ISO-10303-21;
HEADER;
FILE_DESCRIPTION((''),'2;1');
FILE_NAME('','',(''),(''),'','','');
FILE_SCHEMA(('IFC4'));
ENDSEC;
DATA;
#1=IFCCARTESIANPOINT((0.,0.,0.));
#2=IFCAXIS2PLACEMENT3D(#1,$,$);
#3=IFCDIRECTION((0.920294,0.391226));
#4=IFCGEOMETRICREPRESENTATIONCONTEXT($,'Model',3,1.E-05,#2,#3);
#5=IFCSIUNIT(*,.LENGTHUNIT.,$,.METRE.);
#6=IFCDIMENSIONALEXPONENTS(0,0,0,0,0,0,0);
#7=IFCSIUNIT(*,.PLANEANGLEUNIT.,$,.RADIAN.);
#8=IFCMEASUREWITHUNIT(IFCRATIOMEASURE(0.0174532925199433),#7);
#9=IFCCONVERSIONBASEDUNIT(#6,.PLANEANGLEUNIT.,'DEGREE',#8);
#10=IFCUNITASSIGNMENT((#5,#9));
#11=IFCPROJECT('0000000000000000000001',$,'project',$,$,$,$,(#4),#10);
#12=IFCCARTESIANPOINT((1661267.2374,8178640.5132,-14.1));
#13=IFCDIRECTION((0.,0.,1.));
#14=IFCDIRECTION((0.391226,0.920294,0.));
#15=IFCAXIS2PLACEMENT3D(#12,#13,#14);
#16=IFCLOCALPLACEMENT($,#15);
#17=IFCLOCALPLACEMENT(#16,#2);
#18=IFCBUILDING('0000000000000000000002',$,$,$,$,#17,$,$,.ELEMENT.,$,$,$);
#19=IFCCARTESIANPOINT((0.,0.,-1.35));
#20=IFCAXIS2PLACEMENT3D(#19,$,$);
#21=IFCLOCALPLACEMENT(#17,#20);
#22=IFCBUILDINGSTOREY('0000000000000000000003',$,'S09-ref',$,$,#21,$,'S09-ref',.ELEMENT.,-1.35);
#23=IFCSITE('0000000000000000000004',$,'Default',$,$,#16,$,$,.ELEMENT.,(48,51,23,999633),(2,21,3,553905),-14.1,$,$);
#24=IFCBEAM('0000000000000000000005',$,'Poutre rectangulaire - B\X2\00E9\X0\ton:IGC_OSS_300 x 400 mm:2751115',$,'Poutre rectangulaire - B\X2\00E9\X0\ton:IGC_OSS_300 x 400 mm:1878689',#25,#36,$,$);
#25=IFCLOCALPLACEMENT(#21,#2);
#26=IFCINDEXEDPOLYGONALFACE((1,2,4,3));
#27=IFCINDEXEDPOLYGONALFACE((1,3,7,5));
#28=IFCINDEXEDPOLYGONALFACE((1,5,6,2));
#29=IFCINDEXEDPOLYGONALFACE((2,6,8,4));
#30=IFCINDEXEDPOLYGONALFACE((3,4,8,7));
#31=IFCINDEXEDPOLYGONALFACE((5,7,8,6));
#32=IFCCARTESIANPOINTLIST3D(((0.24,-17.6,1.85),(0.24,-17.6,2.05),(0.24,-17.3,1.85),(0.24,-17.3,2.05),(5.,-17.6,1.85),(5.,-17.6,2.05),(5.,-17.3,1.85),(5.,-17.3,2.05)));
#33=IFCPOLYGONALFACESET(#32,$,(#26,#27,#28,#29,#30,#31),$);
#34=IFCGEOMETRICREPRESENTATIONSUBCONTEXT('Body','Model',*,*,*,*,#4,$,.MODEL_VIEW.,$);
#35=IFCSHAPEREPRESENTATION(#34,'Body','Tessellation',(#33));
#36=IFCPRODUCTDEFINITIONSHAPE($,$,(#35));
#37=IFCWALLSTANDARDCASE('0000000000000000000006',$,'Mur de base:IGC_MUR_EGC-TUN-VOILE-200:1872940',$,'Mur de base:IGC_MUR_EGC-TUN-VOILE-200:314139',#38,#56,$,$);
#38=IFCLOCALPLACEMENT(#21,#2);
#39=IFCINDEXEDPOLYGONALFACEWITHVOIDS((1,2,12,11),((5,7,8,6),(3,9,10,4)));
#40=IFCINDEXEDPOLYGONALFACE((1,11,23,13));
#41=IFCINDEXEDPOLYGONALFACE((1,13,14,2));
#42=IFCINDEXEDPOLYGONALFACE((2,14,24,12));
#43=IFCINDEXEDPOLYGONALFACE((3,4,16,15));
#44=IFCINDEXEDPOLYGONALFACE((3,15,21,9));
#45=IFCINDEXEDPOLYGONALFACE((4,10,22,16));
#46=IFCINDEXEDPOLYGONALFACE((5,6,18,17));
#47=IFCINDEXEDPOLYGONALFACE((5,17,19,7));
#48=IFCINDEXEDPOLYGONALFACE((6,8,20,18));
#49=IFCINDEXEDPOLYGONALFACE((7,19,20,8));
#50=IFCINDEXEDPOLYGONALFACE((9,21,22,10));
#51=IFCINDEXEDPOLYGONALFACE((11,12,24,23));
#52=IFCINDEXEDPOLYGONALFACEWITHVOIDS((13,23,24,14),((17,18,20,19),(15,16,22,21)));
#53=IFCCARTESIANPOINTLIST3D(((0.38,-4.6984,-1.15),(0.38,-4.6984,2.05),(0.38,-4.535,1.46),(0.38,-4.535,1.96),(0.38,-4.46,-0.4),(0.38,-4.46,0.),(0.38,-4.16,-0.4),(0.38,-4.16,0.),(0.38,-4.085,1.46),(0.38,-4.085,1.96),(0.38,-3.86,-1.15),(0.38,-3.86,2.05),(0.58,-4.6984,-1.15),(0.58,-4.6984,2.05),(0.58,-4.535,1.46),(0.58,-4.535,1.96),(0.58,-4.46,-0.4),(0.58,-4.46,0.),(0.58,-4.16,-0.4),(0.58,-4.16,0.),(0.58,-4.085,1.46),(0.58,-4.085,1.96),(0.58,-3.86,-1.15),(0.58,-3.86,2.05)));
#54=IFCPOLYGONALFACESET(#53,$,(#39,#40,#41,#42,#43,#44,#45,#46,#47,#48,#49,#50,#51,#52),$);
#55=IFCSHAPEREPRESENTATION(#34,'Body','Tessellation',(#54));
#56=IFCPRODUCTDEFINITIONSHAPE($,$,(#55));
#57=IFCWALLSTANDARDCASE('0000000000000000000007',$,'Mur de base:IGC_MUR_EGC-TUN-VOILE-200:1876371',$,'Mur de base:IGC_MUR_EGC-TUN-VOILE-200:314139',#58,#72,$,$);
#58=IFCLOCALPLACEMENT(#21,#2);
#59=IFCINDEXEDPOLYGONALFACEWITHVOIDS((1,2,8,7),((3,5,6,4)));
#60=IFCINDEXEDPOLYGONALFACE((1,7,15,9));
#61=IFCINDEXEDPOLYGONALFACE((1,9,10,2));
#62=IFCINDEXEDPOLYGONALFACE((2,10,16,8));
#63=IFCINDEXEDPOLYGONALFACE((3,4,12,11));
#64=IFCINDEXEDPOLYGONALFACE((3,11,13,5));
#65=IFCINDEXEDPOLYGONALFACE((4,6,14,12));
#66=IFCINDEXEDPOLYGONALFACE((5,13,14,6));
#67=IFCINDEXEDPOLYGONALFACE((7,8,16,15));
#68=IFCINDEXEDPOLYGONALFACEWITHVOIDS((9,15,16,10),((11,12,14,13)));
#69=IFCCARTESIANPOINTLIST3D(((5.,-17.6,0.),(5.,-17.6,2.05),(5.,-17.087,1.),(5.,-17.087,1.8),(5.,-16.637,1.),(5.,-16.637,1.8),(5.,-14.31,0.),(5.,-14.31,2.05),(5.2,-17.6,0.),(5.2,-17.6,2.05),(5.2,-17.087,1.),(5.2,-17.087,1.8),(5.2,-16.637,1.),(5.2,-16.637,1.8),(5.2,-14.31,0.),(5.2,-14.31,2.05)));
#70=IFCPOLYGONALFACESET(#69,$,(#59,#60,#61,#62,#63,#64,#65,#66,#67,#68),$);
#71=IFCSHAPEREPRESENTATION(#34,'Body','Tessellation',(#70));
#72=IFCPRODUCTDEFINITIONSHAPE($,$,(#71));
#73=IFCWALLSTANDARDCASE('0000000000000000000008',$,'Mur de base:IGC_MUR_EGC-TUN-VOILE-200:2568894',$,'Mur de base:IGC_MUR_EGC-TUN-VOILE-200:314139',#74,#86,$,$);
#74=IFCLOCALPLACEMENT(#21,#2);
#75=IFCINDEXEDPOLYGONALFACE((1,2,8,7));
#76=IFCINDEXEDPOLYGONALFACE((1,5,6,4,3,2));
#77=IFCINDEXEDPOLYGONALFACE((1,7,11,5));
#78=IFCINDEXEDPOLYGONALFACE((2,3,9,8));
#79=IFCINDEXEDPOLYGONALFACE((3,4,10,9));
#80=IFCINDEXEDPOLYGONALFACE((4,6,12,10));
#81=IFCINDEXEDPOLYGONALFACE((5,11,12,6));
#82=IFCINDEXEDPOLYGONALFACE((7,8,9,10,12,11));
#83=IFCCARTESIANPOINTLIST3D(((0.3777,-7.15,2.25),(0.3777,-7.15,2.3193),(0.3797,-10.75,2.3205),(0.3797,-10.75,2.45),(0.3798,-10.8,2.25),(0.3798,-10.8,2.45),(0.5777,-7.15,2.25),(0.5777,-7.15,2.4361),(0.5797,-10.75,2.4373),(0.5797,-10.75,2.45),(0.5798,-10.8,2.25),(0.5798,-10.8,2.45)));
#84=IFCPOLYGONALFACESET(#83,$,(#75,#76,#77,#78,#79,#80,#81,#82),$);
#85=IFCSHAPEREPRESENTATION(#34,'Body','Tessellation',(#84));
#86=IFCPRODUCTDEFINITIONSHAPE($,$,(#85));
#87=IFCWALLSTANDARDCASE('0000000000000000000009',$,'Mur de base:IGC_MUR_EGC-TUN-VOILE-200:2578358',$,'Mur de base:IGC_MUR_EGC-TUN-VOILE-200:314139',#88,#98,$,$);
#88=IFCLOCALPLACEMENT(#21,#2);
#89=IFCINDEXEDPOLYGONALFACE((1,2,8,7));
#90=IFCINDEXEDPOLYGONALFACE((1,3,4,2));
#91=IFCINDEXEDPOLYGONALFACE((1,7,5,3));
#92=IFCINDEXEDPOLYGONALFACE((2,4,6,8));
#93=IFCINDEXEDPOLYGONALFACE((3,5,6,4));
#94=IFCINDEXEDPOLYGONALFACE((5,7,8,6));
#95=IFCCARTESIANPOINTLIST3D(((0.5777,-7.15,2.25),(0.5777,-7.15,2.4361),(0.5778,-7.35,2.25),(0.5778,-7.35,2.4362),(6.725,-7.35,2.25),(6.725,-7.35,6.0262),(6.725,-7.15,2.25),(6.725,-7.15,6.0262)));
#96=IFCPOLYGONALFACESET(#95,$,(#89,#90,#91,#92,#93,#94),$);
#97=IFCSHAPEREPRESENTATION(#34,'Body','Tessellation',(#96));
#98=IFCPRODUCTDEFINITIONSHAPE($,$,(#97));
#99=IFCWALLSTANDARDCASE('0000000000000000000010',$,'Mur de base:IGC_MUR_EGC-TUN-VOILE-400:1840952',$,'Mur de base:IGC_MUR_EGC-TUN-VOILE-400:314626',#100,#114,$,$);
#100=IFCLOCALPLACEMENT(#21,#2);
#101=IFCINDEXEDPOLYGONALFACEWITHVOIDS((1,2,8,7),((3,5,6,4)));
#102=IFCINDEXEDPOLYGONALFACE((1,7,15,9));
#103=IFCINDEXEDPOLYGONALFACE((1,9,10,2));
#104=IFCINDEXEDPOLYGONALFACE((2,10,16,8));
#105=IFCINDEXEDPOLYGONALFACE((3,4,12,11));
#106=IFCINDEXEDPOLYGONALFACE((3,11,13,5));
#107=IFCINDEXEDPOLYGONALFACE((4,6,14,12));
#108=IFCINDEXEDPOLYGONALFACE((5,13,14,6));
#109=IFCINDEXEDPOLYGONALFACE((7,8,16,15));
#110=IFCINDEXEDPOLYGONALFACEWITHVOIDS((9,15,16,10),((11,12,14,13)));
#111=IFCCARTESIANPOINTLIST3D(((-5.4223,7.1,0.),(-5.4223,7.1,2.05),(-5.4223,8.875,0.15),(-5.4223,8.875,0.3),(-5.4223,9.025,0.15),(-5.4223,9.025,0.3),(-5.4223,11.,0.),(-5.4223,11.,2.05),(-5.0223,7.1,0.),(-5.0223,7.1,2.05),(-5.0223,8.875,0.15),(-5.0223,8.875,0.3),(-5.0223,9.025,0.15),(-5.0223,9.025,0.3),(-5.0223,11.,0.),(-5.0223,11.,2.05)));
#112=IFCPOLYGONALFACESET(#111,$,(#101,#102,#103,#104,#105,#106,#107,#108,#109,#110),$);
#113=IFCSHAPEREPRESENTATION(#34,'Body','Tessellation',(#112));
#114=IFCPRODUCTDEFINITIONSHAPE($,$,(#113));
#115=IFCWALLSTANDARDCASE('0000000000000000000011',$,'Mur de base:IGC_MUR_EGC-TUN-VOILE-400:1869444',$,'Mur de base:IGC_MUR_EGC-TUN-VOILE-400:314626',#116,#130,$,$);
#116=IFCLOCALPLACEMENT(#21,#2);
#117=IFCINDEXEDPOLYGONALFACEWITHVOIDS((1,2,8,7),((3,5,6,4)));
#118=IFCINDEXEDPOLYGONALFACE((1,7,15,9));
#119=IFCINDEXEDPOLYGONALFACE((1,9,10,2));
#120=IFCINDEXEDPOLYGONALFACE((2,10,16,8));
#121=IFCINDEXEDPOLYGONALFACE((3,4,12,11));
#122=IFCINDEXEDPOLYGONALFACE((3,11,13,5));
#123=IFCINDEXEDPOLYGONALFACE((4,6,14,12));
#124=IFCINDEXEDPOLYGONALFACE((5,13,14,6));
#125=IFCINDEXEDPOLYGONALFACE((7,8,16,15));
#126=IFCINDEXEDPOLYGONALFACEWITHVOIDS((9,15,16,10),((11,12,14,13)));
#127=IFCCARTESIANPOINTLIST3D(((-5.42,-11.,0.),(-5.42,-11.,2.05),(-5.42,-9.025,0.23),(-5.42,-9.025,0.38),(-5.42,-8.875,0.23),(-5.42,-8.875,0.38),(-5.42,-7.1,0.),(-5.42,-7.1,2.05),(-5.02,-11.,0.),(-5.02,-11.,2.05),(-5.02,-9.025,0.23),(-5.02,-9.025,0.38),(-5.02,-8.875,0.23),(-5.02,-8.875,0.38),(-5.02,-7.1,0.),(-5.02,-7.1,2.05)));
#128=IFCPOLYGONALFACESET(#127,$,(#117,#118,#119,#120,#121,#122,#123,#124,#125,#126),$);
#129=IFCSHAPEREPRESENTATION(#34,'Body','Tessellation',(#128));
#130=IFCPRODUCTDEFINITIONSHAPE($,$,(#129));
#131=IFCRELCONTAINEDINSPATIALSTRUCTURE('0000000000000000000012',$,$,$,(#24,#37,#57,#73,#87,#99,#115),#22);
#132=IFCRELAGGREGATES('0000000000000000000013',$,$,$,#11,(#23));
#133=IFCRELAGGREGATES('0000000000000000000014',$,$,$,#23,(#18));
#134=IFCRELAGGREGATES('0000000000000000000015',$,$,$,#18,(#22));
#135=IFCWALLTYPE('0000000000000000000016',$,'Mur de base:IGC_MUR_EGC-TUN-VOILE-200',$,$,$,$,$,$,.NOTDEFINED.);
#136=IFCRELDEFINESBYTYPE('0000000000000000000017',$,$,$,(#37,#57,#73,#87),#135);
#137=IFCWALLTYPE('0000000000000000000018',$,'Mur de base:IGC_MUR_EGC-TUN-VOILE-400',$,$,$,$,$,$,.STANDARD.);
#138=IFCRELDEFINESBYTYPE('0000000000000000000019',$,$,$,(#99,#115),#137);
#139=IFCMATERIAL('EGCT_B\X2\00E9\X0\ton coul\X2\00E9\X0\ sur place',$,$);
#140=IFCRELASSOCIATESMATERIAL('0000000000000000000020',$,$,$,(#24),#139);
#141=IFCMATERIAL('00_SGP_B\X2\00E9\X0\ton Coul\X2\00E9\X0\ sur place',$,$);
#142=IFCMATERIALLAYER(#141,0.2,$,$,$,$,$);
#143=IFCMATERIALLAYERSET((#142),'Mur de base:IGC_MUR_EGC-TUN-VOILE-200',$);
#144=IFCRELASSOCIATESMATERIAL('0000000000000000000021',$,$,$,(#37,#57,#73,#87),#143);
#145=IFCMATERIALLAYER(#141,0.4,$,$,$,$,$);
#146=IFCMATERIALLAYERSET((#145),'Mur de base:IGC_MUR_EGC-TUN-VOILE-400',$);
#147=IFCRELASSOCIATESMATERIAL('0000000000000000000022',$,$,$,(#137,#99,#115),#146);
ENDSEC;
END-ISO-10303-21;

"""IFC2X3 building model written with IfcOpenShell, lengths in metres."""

from ifc_helpers import new_model, entity, si_unit, converted_unit, direction, frame, frame_2d, origin, place, context, subcontext, project, spatial, polyline, rectangle, outline, extrude, clip, bounded_halfspace, material, layer, layer_set, layer_usage, type_object, element, save


model = new_model("IFC2X3")

# Units and contexts
model_context = context("Model", 3, precision=1e-05, world=origin(), true_north=direction((0.920294, 0.391226)))
body_context = subcontext(model_context, "Body", "Model", "MODEL_VIEW")
ifc_project = project(units=[si_unit("LENGTHUNIT", "METRE"), converted_unit("PLANEANGLEUNIT", "DEGREE", entity("IfcRatioMeasure", 0.0174532925199433), si_unit("PLANEANGLEUNIT", "RADIAN"), dimensions=[0, 0, 0, 0, 0, 0, 0])], contexts=[model_context])

# Site, building, storey
site_placement = place(None, frame((1661267.2374, 8178640.5132, -14.1), z_axis=(0.0, 0.0, 1.0), x_axis=(0.391226, 0.920294, 0.0)))
site = spatial("IfcSite", under=ifc_project, at=site_placement, Name="Default", CompositionType="ELEMENT", RefLatitude=(48, 51, 23, 999633), RefLongitude=(2, 21, 3, 553905), RefElevation=-14.1)
building_placement = place(site_placement, origin())
building = spatial("IfcBuilding", under=site, at=building_placement, CompositionType="ELEMENT")
storey_placement = place(building_placement, frame((0.0, 0.0, -1.35)))
storey = spatial("IfcBuildingStorey", under=building, at=storey_placement, Name="S09-ref", LongName="S09-ref", CompositionType="ELEMENT", Elevation=-1.35)

# Shared definitions
ifc_material_1 = material(Name="EGCT_Béton coulé sur place")

# Beam
beam_placement = place(storey_placement, frame((0.14, -17.45, 2.25)))
element("IfcBeam", 1, at=beam_placement, inside=storey, material=ifc_material_1, Name="Poutre rectangulaire - Béton:IGC_OSS_300 x 400 mm:2751115", ObjectType="Poutre rectangulaire - Béton:IGC_OSS_300 x 400 mm:1878689", context=body_context, shape_type="SweptSolid", body=[
    extrude(rectangle(XDim=0.2, YDim=0.3, at=frame_2d((0.0, 0.0), x_axis=(1.0, 0.0))), frame((0.1, 0.0, -0.3), z_axis=(1.0, 0.0, 0.0), x_axis=(0.0, 0.0, -1.0)), (0.0, 0.0, 1.0), 4.76),
])

# Wall, openings
ifc_material_2 = material(Name="00_SGP_Béton Coulé sur place")
ifc_layer_1 = layer(ifc_material_2, 0.2)
ifc_layer_set_1 = layer_set([ifc_layer_1], Name="Mur de base:IGC_MUR_EGC-TUN-VOILE-200")
wall_type_1 = type_object("IfcWallType", Name="Mur de base:IGC_MUR_EGC-TUN-VOILE-200", PredefinedType="NOTDEFINED")
ifc_layer_usage_1 = layer_usage(ifc_layer_set_1, "AXIS2", "POSITIVE", -0.1)
wall_1_placement = place(storey_placement, frame((0.48, -4.6984, -1.15), z_axis=(0.0, 0.0, 1.0), x_axis=(0.0, 1.0, 0.0)))
wall_1 = element("IfcWallStandardCase", 2, at=wall_1_placement, inside=storey, type_object=wall_type_1, material=ifc_layer_usage_1, Name="Mur de base:IGC_MUR_EGC-TUN-VOILE-200:1872940", ObjectType="Mur de base:IGC_MUR_EGC-TUN-VOILE-200:314139", context=body_context, shape_type="Clipping", body=[
    clip(clip(extrude(rectangle(XDim=0.8384, YDim=0.2, at=frame_2d((0.4192, 0.0), x_axis=(-1.0, 0.0))), origin(), (0.0, 0.0, 1.0), 3.2), bounded_halfspace(frame((0.0, -0.1, 3.2), z_axis=(0.0, 0.0, -1.0), x_axis=(0.0, 1.0, 0.0)), True, frame((0.0, -0.1, 3.2)), polyline([(0.0, 0.0), (0.8384, 0.0), (0.8384, 0.2), (0.0, 0.2), (0.0, 0.0)]))), bounded_halfspace(frame((0.8384, -0.1, 0.0), z_axis=(0.0, 0.0, 1.0), x_axis=(0.0, 1.0, 0.0)), True, frame((0.8384, -0.1, 0.0), z_axis=(0.0, 0.0, 1.0), x_axis=(0.0, 1.0, 0.0)), polyline([(0.0, 0.0), (0.2, 0.0), (0.2, 0.8384), (0.0, 0.8384), (0.0, 0.0)]))),
])
opening_1_placement = place(wall_1_placement, origin())
element("IfcOpeningElement", 3, at=opening_1_placement, cuts=wall_1, ObjectType="Opening", context=body_context, shape_type="SweptSolid", body=[
    extrude(rectangle(XDim=0.4, YDim=0.3, at=frame_2d((0.0, 0.0), x_axis=(0.0, 1.0))), frame((0.3885, -1.624, 0.95), z_axis=(0.0, 1.0, 0.0), x_axis=(1.0, 0.0, 0.0)), (0.0, 0.0, 1.0), 3.048),
])
opening_2_placement = place(wall_1_placement, origin())
element("IfcOpeningElement", 4, at=opening_2_placement, cuts=wall_1, ObjectType="Opening", context=body_context, shape_type="SweptSolid", body=[
    extrude(rectangle(XDim=0.5, YDim=0.45, at=frame_2d((0.0, 0.0), x_axis=(0.0, 1.0))), frame((0.3885, -1.624, 2.86), z_axis=(0.0, 1.0, 0.0), x_axis=(1.0, 0.0, 0.0)), (0.0, 0.0, 1.0), 3.048),
])

# Wall, opening
ifc_layer_usage_2 = layer_usage(ifc_layer_set_1, "AXIS2", "POSITIVE", -0.1)
wall_2_placement = place(storey_placement, frame((5.1, -17.6, 0.0), z_axis=(0.0, 0.0, 1.0), x_axis=(0.0, 1.0, 0.0)))
wall_2 = element("IfcWallStandardCase", 5, at=wall_2_placement, inside=storey, type_object=wall_type_1, material=ifc_layer_usage_2, Name="Mur de base:IGC_MUR_EGC-TUN-VOILE-200:1876371", ObjectType="Mur de base:IGC_MUR_EGC-TUN-VOILE-200:314139", context=body_context, shape_type="Clipping", body=[
    clip(extrude(rectangle(XDim=3.29, YDim=0.2, at=frame_2d((1.645, 0.0), x_axis=(-1.0, 0.0))), origin(), (0.0, 0.0, 1.0), 2.05), bounded_halfspace(frame((0.0, -0.1, 2.05), z_axis=(0.0, 0.0, -1.0), x_axis=(0.0, 1.0, 0.0)), True, frame((0.0, -0.1, 2.05)), polyline([(0.0, 0.0), (0.99, 0.0), (1.19, 0.0), (3.29, 0.0), (3.29, 0.2), (0.0, 0.2), (0.0, 0.0)]))),
])
opening_3_placement = place(wall_2_placement, origin())
element("IfcOpeningElement", 6, at=opening_3_placement, cuts=wall_2, ObjectType="Opening", context=body_context, shape_type="SweptSolid", body=[
    extrude(rectangle(XDim=0.8, YDim=0.45, at=frame_2d((0.0, 0.0), x_axis=(1.0, 0.0))), frame((0.738, -1.424, 1.4), z_axis=(0.0, 1.0, 0.0), x_axis=(0.0, 0.0, -1.0)), (0.0, 0.0, 1.0), 3.048),
])

# Walls
ifc_layer_usage_3 = layer_usage(ifc_layer_set_1, "AXIS2", "NEGATIVE", 0.1)
wall_3_placement = place(storey_placement, frame((0.4777, -7.1499, 2.25), z_axis=(0.0, 0.0, 1.0), x_axis=(0.000575, -1.0, 0.0)))
element("IfcWallStandardCase", 7, at=wall_3_placement, inside=storey, type_object=wall_type_1, material=ifc_layer_usage_3, Name="Mur de base:IGC_MUR_EGC-TUN-VOILE-200:2568894", ObjectType="Mur de base:IGC_MUR_EGC-TUN-VOILE-200:314139", context=body_context, shape_type="Clipping", body=[
    clip(extrude(outline(polyline([(3.65, -0.1), (3.6502, 0.1), (0.2001, 0.1), (0.0001, 0.1), (0.0, -0.1), (3.65, -0.1)])), origin(), (0.0, 0.0, 1.0), 0.2), bounded_halfspace(frame((0.0, -0.1, 0.0693), z_axis=(-0.00029, -0.504305, 0.863525), x_axis=(1.0, -0.000575, 0.0)), False, frame((0.0, -0.1, 0.0693)), polyline([(0.0, 0.0), (3.6, 0.0), (3.6001, 0.2), (0.0001, 0.2), (0.0, 0.0)]))),
])
ifc_layer_usage_4 = layer_usage(ifc_layer_set_1, "AXIS2", "NEGATIVE", 0.1)
wall_4_placement = place(storey_placement, frame((0.5777, -7.25, 2.25)))
element("IfcWallStandardCase", 8, at=wall_4_placement, inside=storey, type_object=wall_type_1, material=ifc_layer_usage_4, Name="Mur de base:IGC_MUR_EGC-TUN-VOILE-200:2578358", ObjectType="Mur de base:IGC_MUR_EGC-TUN-VOILE-200:314139", context=body_context, shape_type="Clipping", body=[
    clip(extrude(outline(polyline([(6.1474, -0.1), (6.1474, 0.1), (5.7723, 0.1), (0.0, 0.1), (0.0001, -0.1), (5.7723, -0.1), (6.1474, -0.1)])), origin(), (0.0, 0.0, 1.0), 3.7762), bounded_halfspace(frame((0.0001, -0.1, 0.1862), z_axis=(-0.504305, 0.0, 0.863525), x_axis=(0.0, -1.0, 0.0)), False, frame((0.0001, -0.1, 0.1862)), polyline([(0.0, 0.0), (5.7722, 0.0), (6.1472, 0.0), (6.1472, 0.2), (-0.0001, 0.2), (0.0, 0.0)]))),
])

# Walls, openings
ifc_layer_2 = layer(ifc_material_2, 0.4)
ifc_layer_set_2 = layer_set([ifc_layer_2], Name="Mur de base:IGC_MUR_EGC-TUN-VOILE-400")
ifc_layer_usage_5 = layer_usage(ifc_layer_set_2, "AXIS2", "NEGATIVE", 0.2)
wall_type_2 = type_object("IfcWallType", Name="Mur de base:IGC_MUR_EGC-TUN-VOILE-400", PredefinedType="STANDARD", material=ifc_layer_set_2)
wall_5_placement = place(storey_placement, frame((-5.2223, 7.1, 0.0), z_axis=(0.0, 0.0, 1.0), x_axis=(-0.000015, 1.0, 0.0)))
wall_5 = element("IfcWallStandardCase", 9, at=wall_5_placement, inside=storey, type_object=wall_type_2, material=ifc_layer_usage_5, Name="Mur de base:IGC_MUR_EGC-TUN-VOILE-400:1840952", ObjectType="Mur de base:IGC_MUR_EGC-TUN-VOILE-400:314626", context=body_context, shape_type="Clipping", body=[
    clip(extrude(rectangle(XDim=3.9, YDim=0.4, at=frame_2d((1.95, 0.0), x_axis=(-1.0, 0.0))), origin(), (0.0, 0.0, 1.0), 2.05), bounded_halfspace(frame((0.0, -0.2, 2.05), z_axis=(0.0, 0.0, -1.0), x_axis=(-0.000015, -1.0, 0.0)), True, frame((0.0, -0.2, 2.05)), polyline([(0.0, 0.0), (3.7, 0.0), (3.9, 0.0), (3.9, 0.4), (0.21, 0.4), (0.01, 0.4), (0.0, 0.4), (0.0, 0.0)]))),
])
opening_4_placement = place(wall_5_placement, origin())
element("IfcOpeningElement", 10, at=opening_4_placement, cuts=wall_5, ObjectType="Opening", context=body_context, shape_type="SweptSolid", body=[
    extrude(rectangle(XDim=0.15, YDim=0.15, at=frame_2d((0.0, 0.0), x_axis=(0.0, 1.0))), frame((1.85, -1.724, 0.225), z_axis=(0.0, 1.0, 0.0), x_axis=(1.0, 0.0, 0.0)), (0.0, 0.0, 1.0), 3.048),
])
ifc_layer_usage_6 = layer_usage(ifc_layer_set_2, "AXIS2", "POSITIVE", -0.2)
wall_6_placement = place(storey_placement, frame((-5.22, -7.1, 0.0), z_axis=(0.0, 0.0, 1.0), x_axis=(0.0, -1.0, 0.0)))
wall_6 = element("IfcWallStandardCase", 11, at=wall_6_placement, inside=storey, type_object=wall_type_2, material=ifc_layer_usage_6, Name="Mur de base:IGC_MUR_EGC-TUN-VOILE-400:1869444", ObjectType="Mur de base:IGC_MUR_EGC-TUN-VOILE-400:314626", context=body_context, shape_type="Clipping", body=[
    clip(extrude(rectangle(XDim=3.9, YDim=0.4, at=frame_2d((1.95, 0.0), x_axis=(-1.0, 0.0))), origin(), (0.0, 0.0, 1.0), 2.05), bounded_halfspace(frame((0.0, -0.2, 2.05), z_axis=(0.0, 0.0, -1.0), x_axis=(0.0, -1.0, 0.0)), True, frame((0.0, -0.2, 2.05)), polyline([(0.0, 0.0), (0.0099, 0.0), (0.2099, 0.0), (3.9, 0.0), (3.9, 0.4), (3.7, 0.4), (0.0, 0.4), (0.0, 0.0)]))),
])
opening_5_placement = place(wall_6_placement, origin())
element("IfcOpeningElement", 12, at=opening_5_placement, cuts=wall_6, ObjectType="Opening", context=body_context, shape_type="SweptSolid", body=[
    extrude(rectangle(XDim=0.15, YDim=0.15, at=frame_2d((0.0, 0.0), x_axis=(0.0, 1.0))), frame((1.85, -1.324, 0.305), z_axis=(0.0, 1.0, 0.0), x_axis=(1.0, 0.0, 0.0)), (0.0, 0.0, 1.0), 3.048),
])

save(model, "model.ifc")
